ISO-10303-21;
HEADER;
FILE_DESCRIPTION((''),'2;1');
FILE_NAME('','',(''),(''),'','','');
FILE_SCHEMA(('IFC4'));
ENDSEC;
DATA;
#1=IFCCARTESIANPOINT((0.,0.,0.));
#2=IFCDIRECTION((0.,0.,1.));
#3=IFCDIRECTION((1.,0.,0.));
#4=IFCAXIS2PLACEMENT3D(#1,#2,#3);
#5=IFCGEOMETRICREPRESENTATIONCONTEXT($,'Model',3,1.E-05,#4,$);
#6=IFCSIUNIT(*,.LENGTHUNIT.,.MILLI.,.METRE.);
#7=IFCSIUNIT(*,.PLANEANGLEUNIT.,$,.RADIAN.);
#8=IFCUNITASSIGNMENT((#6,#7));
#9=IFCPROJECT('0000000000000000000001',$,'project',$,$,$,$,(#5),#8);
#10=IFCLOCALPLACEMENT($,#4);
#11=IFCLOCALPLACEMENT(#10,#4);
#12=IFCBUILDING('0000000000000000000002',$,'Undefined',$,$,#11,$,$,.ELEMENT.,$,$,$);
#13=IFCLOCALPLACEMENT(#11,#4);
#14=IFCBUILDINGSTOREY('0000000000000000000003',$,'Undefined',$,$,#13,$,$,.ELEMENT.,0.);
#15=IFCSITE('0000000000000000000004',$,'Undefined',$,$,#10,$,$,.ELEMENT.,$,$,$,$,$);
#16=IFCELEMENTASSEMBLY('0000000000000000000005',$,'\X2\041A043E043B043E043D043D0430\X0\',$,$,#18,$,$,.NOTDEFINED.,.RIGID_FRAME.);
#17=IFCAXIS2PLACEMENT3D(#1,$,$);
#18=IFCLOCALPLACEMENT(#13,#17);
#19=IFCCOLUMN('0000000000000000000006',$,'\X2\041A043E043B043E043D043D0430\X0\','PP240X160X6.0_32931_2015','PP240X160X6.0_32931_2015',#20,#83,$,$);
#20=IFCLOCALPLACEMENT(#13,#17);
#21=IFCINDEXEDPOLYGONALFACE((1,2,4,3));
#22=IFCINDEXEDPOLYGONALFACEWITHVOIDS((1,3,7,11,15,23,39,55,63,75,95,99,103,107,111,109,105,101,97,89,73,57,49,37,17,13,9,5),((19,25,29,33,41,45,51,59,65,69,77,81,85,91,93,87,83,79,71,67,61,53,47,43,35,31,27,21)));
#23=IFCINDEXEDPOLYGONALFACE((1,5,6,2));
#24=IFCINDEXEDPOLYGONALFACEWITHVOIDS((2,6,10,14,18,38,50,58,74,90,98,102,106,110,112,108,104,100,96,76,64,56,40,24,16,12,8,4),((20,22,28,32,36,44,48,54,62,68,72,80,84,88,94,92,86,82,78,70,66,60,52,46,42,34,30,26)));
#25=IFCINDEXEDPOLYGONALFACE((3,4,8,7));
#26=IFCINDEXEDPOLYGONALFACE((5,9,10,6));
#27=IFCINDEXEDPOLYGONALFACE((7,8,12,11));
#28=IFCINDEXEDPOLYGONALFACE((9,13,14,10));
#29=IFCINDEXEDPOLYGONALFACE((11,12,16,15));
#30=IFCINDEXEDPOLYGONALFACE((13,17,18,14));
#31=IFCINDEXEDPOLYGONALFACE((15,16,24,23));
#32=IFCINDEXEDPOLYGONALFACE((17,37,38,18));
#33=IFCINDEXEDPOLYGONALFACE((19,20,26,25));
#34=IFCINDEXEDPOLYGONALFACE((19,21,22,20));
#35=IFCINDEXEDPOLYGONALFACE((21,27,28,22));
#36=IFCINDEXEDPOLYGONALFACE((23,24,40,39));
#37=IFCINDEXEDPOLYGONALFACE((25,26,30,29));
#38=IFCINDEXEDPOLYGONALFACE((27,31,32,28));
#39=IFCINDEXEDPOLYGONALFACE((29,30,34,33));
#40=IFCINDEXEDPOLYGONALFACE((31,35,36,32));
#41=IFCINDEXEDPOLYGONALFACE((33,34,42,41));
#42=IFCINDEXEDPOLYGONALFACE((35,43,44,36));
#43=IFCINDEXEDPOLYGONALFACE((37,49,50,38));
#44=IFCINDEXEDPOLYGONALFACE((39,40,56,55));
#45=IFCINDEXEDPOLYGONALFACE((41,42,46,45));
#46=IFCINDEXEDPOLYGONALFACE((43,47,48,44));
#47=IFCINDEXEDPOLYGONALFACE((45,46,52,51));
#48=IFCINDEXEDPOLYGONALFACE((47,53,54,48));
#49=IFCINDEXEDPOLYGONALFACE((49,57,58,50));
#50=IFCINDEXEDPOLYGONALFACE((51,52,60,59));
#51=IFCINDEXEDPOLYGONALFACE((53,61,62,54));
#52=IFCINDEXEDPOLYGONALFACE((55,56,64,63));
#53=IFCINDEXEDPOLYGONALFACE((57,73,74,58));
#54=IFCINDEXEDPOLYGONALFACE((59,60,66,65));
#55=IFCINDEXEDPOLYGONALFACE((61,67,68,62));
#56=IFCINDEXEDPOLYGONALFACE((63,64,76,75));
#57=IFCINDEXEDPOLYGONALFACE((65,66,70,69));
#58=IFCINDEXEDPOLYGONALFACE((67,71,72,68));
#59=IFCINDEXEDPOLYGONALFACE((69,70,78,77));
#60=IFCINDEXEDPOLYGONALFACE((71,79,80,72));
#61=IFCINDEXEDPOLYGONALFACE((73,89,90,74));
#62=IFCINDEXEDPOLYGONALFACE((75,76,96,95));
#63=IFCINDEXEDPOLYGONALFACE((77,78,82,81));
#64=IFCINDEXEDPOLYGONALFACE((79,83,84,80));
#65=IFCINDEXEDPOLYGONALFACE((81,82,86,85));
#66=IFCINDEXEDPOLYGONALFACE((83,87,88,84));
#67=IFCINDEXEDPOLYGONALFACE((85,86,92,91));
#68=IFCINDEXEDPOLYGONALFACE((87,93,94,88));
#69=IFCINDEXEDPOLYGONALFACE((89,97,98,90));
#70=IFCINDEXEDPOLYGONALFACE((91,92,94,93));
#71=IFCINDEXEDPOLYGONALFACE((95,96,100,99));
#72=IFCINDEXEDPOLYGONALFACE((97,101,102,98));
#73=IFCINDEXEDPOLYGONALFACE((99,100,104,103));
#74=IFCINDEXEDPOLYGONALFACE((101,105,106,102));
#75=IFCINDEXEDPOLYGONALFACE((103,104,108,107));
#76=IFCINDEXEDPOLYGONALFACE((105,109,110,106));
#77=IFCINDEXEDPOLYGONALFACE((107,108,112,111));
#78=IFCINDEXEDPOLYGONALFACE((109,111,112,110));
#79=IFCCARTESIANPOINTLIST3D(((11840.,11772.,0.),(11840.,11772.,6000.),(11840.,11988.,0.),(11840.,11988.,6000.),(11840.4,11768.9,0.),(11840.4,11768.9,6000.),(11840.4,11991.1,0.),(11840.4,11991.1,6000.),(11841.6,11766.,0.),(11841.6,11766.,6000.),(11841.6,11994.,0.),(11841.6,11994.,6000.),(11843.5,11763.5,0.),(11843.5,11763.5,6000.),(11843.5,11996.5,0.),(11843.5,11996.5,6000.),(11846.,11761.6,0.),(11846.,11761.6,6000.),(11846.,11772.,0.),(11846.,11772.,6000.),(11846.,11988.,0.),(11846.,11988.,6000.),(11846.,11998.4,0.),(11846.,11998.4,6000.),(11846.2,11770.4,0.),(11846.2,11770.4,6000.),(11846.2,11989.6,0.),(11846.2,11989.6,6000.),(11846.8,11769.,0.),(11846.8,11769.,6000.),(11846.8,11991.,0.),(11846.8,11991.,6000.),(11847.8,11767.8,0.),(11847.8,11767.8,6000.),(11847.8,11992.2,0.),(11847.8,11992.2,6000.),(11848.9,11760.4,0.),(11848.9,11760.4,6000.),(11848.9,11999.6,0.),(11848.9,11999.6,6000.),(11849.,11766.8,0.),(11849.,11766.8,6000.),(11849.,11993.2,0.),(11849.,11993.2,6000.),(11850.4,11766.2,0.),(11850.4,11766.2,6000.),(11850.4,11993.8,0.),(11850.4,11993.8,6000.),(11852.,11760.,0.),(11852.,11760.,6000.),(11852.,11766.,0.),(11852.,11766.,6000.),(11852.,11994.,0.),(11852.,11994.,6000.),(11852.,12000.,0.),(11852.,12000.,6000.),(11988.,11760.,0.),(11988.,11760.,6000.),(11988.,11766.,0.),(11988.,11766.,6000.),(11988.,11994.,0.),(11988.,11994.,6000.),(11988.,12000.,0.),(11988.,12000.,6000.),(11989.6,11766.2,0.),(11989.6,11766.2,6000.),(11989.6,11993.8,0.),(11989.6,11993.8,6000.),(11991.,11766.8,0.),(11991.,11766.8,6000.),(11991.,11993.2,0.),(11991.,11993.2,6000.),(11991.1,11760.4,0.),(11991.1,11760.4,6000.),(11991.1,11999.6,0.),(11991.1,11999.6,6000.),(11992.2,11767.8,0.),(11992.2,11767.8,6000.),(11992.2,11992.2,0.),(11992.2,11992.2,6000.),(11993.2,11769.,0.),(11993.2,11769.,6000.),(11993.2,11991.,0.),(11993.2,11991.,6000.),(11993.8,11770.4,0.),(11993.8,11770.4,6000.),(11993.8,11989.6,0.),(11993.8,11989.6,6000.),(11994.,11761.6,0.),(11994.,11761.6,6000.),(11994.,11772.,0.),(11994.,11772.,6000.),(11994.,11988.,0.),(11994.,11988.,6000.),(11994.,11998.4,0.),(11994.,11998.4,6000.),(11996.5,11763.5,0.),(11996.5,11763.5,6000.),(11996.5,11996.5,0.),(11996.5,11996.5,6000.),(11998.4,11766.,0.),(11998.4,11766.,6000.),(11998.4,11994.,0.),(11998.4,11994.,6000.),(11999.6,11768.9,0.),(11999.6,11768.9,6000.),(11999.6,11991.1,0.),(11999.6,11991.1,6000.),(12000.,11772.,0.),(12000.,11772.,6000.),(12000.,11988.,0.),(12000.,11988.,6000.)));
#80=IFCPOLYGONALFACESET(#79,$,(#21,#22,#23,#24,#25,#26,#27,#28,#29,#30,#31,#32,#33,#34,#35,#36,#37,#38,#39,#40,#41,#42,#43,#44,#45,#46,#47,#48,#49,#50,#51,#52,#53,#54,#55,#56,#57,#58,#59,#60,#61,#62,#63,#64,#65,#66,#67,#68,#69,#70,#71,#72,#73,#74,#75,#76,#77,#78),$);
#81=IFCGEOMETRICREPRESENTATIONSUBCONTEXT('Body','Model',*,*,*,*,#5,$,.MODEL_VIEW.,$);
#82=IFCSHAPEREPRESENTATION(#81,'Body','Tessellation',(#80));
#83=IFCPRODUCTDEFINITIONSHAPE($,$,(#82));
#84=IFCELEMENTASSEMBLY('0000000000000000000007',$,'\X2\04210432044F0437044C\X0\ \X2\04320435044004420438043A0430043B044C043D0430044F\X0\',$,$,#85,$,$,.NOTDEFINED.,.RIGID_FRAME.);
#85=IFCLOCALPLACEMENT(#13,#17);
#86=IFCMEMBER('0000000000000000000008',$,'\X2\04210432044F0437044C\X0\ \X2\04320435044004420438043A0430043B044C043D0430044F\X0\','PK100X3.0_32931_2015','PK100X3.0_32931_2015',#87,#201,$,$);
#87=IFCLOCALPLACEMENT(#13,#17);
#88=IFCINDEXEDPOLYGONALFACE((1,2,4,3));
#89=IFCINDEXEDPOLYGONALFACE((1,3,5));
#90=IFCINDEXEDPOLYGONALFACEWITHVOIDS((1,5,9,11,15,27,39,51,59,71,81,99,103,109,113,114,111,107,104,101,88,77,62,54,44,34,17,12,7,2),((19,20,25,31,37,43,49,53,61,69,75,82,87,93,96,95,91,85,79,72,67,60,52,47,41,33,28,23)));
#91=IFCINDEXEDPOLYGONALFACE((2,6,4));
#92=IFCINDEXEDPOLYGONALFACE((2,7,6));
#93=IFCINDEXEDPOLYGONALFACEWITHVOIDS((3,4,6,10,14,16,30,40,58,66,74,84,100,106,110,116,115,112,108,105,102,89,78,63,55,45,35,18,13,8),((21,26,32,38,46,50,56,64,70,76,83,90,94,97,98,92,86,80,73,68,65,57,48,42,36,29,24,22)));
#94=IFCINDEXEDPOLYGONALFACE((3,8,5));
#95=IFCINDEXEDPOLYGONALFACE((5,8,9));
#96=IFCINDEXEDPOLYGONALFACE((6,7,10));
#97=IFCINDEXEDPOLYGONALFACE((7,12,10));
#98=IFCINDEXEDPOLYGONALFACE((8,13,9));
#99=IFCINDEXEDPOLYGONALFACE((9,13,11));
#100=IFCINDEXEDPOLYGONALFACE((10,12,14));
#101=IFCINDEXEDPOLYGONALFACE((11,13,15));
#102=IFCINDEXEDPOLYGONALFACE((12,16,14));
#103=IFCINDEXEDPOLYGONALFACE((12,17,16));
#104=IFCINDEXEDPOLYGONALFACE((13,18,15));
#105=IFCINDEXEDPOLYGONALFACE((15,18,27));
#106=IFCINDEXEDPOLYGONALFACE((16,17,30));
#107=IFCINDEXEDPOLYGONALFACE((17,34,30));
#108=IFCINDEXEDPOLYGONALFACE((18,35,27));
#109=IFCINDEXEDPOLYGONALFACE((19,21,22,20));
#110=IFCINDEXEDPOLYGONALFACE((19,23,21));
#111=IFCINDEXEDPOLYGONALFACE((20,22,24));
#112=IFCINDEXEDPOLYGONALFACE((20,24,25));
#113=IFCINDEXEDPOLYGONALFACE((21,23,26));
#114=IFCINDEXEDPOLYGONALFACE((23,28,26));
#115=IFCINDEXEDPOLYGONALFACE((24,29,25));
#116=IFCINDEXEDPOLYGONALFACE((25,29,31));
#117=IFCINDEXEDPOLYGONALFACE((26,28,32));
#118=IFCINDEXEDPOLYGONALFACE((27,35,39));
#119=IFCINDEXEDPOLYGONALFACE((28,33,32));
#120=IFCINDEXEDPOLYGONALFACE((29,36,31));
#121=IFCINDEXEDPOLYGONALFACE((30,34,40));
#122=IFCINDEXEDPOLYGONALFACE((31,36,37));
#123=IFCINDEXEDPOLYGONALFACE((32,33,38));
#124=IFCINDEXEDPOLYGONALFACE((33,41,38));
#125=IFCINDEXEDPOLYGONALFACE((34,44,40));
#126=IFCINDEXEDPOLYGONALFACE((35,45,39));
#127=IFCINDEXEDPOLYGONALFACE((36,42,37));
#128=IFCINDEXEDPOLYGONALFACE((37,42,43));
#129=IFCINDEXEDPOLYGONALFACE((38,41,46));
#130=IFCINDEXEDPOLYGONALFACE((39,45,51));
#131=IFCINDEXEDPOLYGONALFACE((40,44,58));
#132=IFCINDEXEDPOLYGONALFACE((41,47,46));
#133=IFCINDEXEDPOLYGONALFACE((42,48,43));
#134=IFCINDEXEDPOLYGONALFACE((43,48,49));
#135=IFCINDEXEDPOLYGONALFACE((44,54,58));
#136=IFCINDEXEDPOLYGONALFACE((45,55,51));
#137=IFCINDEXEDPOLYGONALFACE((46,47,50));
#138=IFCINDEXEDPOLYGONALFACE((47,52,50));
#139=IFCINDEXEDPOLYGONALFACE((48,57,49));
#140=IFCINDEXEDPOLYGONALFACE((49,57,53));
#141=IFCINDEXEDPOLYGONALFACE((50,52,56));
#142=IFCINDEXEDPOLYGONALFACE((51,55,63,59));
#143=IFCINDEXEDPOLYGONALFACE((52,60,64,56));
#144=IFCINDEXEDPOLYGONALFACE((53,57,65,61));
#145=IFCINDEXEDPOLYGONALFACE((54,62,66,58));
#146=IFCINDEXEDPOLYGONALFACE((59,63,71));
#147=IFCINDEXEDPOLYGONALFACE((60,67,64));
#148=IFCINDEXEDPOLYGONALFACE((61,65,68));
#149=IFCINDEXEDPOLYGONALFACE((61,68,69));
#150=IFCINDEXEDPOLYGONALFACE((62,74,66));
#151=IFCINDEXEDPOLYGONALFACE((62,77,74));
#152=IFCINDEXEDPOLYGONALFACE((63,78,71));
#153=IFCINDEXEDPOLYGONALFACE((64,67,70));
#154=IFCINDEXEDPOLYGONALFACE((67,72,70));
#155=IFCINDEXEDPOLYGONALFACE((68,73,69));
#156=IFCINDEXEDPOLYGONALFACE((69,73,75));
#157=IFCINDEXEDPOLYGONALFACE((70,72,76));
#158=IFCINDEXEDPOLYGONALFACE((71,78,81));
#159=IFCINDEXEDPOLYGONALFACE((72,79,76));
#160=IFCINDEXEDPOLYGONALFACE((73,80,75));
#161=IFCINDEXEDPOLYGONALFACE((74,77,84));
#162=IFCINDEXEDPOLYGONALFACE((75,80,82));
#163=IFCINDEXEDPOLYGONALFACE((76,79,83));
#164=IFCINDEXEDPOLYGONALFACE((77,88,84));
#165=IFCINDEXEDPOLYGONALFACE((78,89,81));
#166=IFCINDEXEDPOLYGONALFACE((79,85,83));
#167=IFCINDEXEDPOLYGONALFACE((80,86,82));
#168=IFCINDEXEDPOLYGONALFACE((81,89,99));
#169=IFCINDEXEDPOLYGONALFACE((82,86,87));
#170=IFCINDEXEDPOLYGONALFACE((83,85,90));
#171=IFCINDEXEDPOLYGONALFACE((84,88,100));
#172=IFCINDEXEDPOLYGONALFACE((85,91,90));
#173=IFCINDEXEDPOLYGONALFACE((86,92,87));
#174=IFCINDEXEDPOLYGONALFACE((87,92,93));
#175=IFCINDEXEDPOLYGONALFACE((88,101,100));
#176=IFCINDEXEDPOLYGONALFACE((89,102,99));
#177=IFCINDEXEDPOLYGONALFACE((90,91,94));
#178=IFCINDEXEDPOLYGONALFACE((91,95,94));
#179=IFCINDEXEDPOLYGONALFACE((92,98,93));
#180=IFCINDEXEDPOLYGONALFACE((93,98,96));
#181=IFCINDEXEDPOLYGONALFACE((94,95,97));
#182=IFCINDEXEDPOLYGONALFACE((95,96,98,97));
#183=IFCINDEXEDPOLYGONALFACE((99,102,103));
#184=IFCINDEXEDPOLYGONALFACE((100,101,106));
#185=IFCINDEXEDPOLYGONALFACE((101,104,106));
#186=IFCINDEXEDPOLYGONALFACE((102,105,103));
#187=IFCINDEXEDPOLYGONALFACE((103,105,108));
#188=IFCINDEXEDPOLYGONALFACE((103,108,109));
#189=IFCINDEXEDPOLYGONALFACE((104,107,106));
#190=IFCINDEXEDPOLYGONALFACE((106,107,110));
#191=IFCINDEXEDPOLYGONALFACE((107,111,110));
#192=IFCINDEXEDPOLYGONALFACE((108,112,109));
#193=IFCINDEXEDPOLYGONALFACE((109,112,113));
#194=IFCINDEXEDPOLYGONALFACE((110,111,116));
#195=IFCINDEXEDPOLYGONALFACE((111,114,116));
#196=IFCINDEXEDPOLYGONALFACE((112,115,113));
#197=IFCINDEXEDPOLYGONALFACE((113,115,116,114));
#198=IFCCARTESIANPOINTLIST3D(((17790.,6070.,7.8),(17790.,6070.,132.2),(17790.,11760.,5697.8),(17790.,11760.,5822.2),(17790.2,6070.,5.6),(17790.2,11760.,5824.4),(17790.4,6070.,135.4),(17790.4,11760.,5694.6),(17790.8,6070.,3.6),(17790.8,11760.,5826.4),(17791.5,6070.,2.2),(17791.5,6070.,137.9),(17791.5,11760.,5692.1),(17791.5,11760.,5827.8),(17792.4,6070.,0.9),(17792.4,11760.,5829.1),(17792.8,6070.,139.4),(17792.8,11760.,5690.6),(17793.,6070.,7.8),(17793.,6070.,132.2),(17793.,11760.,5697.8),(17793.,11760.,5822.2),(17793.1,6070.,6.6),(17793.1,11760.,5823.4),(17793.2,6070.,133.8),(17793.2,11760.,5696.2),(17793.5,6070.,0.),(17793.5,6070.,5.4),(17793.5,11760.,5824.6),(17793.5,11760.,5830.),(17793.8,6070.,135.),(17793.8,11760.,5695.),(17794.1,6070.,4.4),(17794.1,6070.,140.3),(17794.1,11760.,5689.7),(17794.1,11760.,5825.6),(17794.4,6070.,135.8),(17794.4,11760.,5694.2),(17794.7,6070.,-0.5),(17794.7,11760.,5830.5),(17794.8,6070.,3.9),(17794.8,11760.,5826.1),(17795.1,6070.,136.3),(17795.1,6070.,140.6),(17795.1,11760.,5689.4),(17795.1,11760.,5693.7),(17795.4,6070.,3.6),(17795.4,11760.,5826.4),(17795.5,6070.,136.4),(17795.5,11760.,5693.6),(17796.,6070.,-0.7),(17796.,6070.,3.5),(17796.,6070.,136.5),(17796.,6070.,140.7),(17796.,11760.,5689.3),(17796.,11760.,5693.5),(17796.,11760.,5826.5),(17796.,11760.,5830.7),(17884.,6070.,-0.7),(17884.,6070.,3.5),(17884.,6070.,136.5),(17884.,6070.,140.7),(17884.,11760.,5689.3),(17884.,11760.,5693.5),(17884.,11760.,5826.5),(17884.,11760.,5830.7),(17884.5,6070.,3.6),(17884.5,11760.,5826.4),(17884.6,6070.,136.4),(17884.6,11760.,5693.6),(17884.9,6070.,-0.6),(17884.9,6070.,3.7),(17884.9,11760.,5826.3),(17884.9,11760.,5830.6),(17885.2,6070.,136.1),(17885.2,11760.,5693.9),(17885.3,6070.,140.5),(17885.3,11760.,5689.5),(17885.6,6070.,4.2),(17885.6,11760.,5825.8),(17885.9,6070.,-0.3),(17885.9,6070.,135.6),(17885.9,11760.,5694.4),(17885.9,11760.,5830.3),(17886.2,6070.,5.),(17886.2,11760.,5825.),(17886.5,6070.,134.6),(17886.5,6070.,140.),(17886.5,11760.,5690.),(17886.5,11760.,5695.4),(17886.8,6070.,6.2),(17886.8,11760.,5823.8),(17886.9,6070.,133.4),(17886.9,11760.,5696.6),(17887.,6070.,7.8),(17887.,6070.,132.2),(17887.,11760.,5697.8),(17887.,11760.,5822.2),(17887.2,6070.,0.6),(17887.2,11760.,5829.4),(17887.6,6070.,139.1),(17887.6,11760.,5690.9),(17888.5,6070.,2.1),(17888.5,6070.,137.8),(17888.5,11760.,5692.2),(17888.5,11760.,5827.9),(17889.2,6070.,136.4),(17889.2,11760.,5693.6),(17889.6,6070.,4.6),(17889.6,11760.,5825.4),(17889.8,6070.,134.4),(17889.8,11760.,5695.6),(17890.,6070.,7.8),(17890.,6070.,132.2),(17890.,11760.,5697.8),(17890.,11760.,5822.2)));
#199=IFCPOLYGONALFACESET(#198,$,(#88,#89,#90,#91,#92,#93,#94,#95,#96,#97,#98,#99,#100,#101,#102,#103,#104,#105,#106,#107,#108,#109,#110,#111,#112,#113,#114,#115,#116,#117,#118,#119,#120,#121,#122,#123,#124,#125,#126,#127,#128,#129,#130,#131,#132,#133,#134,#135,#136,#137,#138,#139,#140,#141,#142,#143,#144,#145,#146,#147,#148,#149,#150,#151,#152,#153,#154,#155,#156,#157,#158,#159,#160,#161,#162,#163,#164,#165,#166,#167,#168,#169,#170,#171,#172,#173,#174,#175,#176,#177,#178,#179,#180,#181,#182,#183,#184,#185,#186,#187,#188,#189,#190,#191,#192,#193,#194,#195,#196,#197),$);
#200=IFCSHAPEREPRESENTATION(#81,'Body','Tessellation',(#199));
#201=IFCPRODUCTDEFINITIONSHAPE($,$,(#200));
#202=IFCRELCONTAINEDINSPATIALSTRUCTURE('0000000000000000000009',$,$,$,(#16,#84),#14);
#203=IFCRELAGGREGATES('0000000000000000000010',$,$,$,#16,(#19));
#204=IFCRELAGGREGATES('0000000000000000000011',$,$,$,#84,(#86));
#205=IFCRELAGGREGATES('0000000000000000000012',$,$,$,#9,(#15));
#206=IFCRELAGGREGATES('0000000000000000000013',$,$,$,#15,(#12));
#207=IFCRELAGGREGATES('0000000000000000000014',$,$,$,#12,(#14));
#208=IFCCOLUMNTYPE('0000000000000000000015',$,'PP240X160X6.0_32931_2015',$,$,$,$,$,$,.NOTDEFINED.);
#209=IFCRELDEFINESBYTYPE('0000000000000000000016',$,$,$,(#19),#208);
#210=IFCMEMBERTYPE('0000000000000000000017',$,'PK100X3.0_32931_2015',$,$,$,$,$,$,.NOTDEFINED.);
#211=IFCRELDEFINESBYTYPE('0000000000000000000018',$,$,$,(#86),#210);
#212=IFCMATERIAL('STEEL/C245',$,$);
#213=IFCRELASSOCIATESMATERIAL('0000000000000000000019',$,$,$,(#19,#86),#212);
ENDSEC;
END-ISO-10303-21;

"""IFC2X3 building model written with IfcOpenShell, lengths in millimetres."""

from ifc_helpers import new_model, si_unit, frame, origin_with_axes, origin_2d_with_axis, place, context, subcontext, project, spatial, hollow_rectangle, extrude, clip, halfspace, material, type_object, element, aggregate, save


model = new_model("IFC2X3")

# Units and contexts
model_context = context("Model", 3, precision=1e-05, world=origin_with_axes())
body_context = subcontext(model_context, "Body", "Model", "MODEL_VIEW")
ifc_project = project(units=[si_unit("LENGTHUNIT", "METRE", prefix="MILLI"), si_unit("PLANEANGLEUNIT", "RADIAN")], contexts=[model_context])

# Site, building, storey
site_placement = place(None, origin_with_axes())
site = spatial("IfcSite", under=ifc_project, at=site_placement, Name="Undefined", CompositionType="ELEMENT")
building_placement = place(site_placement, origin_with_axes())
building = spatial("IfcBuilding", under=site, at=building_placement, Name="Undefined", CompositionType="ELEMENT")
storey_placement = place(building_placement, origin_with_axes())
storey = spatial("IfcBuildingStorey", under=building, at=storey_placement, Name="Undefined", CompositionType="ELEMENT", Elevation=0.0)

# Element assembly, column
ifc_material = material(Name="STEEL/C245")
column_type_1 = type_object("IfcColumnType", Name="PP240X160X6.0_32931_2015", PredefinedType="NOTDEFINED")
assembly_1_placement = place(storey_placement, origin_with_axes())
assembly_1 = element("IfcElementAssembly", 1, at=assembly_1_placement, inside=storey, Name="Колонна", AssemblyPlace="NOTDEFINED", PredefinedType="RIGID_FRAME")
column_1_placement = place(assembly_1_placement, frame((11920.0, 11880.0, 0.0), z_axis=(0.0, 0.0, 1.0), x_axis=(0.0, -1.0, 0.0)))
column_1 = element("IfcColumn", 2, at=column_1_placement, type_object=column_type_1, material=ifc_material, Name="Колонна", Description="PP240X160X6.0_32931_2015", ObjectType="PP240X160X6.0_32931_2015", context=body_context, shape_type="SweptSolid", body=[
    extrude(hollow_rectangle(XDim=160.0, YDim=240.0, WallThickness=6.0, InnerFilletRadius=6.0, OuterFilletRadius=12.0, at=origin_2d_with_axis()), frame((0.0, 0.0, 6000.0), z_axis=(0.0, 0.0, -1.0), x_axis=(0.0, 1.0, 0.0)), (0.0, 0.0, 1.0), 6000.0),
])
aggregate(assembly_1, [column_1])

# Element assembly, member
member_type_1 = type_object("IfcMemberType", Name="PK100X3.0_32931_2015", PredefinedType="NOTDEFINED")
assembly_2_placement = place(storey_placement, origin_with_axes())
assembly_2 = element("IfcElementAssembly", 3, at=assembly_2_placement, inside=storey, Name="Связь вертикальная", AssemblyPlace="NOTDEFINED", PredefinedType="RIGID_FRAME")
member_1_placement = place(assembly_2_placement, frame((17840.0, 6000.0, 0.0), z_axis=(0.0, -0.707107, 0.707107), x_axis=(0.0, 0.707107, 0.707107)))
member_1 = element("IfcMember", 4, at=member_1_placement, type_object=member_type_1, material=ifc_material, Name="Связь вертикальная", Description="PK100X3.0_32931_2015", ObjectType="PK100X3.0_32931_2015", context=body_context, shape_type="Clipping", body=[
    clip(clip(extrude(hollow_rectangle(XDim=100.0, YDim=100.0, WallThickness=3.0, InnerFilletRadius=3.0, OuterFilletRadius=6.0, at=origin_2d_with_axis()), frame((8246.9, 0.0, 0.0), z_axis=(-1.0, 0.0, 0.0), x_axis=(0.0, -1.0, 0.0)), (0.0, 0.0, 1.0), 8248.9), halfspace(frame((8016.6, 0.0, -129.3), z_axis=(-0.707107, 0.0, 0.707107), x_axis=(-0.707107, 0.0, -0.707107)), True)), halfspace(frame((186.9, 0.0, 87.9), z_axis=(0.707107, 0.0, -0.707107), x_axis=(0.707107, 0.0, 0.707107)), True)),
])
aggregate(assembly_2, [member_1])

save(model, "model.ifc")
